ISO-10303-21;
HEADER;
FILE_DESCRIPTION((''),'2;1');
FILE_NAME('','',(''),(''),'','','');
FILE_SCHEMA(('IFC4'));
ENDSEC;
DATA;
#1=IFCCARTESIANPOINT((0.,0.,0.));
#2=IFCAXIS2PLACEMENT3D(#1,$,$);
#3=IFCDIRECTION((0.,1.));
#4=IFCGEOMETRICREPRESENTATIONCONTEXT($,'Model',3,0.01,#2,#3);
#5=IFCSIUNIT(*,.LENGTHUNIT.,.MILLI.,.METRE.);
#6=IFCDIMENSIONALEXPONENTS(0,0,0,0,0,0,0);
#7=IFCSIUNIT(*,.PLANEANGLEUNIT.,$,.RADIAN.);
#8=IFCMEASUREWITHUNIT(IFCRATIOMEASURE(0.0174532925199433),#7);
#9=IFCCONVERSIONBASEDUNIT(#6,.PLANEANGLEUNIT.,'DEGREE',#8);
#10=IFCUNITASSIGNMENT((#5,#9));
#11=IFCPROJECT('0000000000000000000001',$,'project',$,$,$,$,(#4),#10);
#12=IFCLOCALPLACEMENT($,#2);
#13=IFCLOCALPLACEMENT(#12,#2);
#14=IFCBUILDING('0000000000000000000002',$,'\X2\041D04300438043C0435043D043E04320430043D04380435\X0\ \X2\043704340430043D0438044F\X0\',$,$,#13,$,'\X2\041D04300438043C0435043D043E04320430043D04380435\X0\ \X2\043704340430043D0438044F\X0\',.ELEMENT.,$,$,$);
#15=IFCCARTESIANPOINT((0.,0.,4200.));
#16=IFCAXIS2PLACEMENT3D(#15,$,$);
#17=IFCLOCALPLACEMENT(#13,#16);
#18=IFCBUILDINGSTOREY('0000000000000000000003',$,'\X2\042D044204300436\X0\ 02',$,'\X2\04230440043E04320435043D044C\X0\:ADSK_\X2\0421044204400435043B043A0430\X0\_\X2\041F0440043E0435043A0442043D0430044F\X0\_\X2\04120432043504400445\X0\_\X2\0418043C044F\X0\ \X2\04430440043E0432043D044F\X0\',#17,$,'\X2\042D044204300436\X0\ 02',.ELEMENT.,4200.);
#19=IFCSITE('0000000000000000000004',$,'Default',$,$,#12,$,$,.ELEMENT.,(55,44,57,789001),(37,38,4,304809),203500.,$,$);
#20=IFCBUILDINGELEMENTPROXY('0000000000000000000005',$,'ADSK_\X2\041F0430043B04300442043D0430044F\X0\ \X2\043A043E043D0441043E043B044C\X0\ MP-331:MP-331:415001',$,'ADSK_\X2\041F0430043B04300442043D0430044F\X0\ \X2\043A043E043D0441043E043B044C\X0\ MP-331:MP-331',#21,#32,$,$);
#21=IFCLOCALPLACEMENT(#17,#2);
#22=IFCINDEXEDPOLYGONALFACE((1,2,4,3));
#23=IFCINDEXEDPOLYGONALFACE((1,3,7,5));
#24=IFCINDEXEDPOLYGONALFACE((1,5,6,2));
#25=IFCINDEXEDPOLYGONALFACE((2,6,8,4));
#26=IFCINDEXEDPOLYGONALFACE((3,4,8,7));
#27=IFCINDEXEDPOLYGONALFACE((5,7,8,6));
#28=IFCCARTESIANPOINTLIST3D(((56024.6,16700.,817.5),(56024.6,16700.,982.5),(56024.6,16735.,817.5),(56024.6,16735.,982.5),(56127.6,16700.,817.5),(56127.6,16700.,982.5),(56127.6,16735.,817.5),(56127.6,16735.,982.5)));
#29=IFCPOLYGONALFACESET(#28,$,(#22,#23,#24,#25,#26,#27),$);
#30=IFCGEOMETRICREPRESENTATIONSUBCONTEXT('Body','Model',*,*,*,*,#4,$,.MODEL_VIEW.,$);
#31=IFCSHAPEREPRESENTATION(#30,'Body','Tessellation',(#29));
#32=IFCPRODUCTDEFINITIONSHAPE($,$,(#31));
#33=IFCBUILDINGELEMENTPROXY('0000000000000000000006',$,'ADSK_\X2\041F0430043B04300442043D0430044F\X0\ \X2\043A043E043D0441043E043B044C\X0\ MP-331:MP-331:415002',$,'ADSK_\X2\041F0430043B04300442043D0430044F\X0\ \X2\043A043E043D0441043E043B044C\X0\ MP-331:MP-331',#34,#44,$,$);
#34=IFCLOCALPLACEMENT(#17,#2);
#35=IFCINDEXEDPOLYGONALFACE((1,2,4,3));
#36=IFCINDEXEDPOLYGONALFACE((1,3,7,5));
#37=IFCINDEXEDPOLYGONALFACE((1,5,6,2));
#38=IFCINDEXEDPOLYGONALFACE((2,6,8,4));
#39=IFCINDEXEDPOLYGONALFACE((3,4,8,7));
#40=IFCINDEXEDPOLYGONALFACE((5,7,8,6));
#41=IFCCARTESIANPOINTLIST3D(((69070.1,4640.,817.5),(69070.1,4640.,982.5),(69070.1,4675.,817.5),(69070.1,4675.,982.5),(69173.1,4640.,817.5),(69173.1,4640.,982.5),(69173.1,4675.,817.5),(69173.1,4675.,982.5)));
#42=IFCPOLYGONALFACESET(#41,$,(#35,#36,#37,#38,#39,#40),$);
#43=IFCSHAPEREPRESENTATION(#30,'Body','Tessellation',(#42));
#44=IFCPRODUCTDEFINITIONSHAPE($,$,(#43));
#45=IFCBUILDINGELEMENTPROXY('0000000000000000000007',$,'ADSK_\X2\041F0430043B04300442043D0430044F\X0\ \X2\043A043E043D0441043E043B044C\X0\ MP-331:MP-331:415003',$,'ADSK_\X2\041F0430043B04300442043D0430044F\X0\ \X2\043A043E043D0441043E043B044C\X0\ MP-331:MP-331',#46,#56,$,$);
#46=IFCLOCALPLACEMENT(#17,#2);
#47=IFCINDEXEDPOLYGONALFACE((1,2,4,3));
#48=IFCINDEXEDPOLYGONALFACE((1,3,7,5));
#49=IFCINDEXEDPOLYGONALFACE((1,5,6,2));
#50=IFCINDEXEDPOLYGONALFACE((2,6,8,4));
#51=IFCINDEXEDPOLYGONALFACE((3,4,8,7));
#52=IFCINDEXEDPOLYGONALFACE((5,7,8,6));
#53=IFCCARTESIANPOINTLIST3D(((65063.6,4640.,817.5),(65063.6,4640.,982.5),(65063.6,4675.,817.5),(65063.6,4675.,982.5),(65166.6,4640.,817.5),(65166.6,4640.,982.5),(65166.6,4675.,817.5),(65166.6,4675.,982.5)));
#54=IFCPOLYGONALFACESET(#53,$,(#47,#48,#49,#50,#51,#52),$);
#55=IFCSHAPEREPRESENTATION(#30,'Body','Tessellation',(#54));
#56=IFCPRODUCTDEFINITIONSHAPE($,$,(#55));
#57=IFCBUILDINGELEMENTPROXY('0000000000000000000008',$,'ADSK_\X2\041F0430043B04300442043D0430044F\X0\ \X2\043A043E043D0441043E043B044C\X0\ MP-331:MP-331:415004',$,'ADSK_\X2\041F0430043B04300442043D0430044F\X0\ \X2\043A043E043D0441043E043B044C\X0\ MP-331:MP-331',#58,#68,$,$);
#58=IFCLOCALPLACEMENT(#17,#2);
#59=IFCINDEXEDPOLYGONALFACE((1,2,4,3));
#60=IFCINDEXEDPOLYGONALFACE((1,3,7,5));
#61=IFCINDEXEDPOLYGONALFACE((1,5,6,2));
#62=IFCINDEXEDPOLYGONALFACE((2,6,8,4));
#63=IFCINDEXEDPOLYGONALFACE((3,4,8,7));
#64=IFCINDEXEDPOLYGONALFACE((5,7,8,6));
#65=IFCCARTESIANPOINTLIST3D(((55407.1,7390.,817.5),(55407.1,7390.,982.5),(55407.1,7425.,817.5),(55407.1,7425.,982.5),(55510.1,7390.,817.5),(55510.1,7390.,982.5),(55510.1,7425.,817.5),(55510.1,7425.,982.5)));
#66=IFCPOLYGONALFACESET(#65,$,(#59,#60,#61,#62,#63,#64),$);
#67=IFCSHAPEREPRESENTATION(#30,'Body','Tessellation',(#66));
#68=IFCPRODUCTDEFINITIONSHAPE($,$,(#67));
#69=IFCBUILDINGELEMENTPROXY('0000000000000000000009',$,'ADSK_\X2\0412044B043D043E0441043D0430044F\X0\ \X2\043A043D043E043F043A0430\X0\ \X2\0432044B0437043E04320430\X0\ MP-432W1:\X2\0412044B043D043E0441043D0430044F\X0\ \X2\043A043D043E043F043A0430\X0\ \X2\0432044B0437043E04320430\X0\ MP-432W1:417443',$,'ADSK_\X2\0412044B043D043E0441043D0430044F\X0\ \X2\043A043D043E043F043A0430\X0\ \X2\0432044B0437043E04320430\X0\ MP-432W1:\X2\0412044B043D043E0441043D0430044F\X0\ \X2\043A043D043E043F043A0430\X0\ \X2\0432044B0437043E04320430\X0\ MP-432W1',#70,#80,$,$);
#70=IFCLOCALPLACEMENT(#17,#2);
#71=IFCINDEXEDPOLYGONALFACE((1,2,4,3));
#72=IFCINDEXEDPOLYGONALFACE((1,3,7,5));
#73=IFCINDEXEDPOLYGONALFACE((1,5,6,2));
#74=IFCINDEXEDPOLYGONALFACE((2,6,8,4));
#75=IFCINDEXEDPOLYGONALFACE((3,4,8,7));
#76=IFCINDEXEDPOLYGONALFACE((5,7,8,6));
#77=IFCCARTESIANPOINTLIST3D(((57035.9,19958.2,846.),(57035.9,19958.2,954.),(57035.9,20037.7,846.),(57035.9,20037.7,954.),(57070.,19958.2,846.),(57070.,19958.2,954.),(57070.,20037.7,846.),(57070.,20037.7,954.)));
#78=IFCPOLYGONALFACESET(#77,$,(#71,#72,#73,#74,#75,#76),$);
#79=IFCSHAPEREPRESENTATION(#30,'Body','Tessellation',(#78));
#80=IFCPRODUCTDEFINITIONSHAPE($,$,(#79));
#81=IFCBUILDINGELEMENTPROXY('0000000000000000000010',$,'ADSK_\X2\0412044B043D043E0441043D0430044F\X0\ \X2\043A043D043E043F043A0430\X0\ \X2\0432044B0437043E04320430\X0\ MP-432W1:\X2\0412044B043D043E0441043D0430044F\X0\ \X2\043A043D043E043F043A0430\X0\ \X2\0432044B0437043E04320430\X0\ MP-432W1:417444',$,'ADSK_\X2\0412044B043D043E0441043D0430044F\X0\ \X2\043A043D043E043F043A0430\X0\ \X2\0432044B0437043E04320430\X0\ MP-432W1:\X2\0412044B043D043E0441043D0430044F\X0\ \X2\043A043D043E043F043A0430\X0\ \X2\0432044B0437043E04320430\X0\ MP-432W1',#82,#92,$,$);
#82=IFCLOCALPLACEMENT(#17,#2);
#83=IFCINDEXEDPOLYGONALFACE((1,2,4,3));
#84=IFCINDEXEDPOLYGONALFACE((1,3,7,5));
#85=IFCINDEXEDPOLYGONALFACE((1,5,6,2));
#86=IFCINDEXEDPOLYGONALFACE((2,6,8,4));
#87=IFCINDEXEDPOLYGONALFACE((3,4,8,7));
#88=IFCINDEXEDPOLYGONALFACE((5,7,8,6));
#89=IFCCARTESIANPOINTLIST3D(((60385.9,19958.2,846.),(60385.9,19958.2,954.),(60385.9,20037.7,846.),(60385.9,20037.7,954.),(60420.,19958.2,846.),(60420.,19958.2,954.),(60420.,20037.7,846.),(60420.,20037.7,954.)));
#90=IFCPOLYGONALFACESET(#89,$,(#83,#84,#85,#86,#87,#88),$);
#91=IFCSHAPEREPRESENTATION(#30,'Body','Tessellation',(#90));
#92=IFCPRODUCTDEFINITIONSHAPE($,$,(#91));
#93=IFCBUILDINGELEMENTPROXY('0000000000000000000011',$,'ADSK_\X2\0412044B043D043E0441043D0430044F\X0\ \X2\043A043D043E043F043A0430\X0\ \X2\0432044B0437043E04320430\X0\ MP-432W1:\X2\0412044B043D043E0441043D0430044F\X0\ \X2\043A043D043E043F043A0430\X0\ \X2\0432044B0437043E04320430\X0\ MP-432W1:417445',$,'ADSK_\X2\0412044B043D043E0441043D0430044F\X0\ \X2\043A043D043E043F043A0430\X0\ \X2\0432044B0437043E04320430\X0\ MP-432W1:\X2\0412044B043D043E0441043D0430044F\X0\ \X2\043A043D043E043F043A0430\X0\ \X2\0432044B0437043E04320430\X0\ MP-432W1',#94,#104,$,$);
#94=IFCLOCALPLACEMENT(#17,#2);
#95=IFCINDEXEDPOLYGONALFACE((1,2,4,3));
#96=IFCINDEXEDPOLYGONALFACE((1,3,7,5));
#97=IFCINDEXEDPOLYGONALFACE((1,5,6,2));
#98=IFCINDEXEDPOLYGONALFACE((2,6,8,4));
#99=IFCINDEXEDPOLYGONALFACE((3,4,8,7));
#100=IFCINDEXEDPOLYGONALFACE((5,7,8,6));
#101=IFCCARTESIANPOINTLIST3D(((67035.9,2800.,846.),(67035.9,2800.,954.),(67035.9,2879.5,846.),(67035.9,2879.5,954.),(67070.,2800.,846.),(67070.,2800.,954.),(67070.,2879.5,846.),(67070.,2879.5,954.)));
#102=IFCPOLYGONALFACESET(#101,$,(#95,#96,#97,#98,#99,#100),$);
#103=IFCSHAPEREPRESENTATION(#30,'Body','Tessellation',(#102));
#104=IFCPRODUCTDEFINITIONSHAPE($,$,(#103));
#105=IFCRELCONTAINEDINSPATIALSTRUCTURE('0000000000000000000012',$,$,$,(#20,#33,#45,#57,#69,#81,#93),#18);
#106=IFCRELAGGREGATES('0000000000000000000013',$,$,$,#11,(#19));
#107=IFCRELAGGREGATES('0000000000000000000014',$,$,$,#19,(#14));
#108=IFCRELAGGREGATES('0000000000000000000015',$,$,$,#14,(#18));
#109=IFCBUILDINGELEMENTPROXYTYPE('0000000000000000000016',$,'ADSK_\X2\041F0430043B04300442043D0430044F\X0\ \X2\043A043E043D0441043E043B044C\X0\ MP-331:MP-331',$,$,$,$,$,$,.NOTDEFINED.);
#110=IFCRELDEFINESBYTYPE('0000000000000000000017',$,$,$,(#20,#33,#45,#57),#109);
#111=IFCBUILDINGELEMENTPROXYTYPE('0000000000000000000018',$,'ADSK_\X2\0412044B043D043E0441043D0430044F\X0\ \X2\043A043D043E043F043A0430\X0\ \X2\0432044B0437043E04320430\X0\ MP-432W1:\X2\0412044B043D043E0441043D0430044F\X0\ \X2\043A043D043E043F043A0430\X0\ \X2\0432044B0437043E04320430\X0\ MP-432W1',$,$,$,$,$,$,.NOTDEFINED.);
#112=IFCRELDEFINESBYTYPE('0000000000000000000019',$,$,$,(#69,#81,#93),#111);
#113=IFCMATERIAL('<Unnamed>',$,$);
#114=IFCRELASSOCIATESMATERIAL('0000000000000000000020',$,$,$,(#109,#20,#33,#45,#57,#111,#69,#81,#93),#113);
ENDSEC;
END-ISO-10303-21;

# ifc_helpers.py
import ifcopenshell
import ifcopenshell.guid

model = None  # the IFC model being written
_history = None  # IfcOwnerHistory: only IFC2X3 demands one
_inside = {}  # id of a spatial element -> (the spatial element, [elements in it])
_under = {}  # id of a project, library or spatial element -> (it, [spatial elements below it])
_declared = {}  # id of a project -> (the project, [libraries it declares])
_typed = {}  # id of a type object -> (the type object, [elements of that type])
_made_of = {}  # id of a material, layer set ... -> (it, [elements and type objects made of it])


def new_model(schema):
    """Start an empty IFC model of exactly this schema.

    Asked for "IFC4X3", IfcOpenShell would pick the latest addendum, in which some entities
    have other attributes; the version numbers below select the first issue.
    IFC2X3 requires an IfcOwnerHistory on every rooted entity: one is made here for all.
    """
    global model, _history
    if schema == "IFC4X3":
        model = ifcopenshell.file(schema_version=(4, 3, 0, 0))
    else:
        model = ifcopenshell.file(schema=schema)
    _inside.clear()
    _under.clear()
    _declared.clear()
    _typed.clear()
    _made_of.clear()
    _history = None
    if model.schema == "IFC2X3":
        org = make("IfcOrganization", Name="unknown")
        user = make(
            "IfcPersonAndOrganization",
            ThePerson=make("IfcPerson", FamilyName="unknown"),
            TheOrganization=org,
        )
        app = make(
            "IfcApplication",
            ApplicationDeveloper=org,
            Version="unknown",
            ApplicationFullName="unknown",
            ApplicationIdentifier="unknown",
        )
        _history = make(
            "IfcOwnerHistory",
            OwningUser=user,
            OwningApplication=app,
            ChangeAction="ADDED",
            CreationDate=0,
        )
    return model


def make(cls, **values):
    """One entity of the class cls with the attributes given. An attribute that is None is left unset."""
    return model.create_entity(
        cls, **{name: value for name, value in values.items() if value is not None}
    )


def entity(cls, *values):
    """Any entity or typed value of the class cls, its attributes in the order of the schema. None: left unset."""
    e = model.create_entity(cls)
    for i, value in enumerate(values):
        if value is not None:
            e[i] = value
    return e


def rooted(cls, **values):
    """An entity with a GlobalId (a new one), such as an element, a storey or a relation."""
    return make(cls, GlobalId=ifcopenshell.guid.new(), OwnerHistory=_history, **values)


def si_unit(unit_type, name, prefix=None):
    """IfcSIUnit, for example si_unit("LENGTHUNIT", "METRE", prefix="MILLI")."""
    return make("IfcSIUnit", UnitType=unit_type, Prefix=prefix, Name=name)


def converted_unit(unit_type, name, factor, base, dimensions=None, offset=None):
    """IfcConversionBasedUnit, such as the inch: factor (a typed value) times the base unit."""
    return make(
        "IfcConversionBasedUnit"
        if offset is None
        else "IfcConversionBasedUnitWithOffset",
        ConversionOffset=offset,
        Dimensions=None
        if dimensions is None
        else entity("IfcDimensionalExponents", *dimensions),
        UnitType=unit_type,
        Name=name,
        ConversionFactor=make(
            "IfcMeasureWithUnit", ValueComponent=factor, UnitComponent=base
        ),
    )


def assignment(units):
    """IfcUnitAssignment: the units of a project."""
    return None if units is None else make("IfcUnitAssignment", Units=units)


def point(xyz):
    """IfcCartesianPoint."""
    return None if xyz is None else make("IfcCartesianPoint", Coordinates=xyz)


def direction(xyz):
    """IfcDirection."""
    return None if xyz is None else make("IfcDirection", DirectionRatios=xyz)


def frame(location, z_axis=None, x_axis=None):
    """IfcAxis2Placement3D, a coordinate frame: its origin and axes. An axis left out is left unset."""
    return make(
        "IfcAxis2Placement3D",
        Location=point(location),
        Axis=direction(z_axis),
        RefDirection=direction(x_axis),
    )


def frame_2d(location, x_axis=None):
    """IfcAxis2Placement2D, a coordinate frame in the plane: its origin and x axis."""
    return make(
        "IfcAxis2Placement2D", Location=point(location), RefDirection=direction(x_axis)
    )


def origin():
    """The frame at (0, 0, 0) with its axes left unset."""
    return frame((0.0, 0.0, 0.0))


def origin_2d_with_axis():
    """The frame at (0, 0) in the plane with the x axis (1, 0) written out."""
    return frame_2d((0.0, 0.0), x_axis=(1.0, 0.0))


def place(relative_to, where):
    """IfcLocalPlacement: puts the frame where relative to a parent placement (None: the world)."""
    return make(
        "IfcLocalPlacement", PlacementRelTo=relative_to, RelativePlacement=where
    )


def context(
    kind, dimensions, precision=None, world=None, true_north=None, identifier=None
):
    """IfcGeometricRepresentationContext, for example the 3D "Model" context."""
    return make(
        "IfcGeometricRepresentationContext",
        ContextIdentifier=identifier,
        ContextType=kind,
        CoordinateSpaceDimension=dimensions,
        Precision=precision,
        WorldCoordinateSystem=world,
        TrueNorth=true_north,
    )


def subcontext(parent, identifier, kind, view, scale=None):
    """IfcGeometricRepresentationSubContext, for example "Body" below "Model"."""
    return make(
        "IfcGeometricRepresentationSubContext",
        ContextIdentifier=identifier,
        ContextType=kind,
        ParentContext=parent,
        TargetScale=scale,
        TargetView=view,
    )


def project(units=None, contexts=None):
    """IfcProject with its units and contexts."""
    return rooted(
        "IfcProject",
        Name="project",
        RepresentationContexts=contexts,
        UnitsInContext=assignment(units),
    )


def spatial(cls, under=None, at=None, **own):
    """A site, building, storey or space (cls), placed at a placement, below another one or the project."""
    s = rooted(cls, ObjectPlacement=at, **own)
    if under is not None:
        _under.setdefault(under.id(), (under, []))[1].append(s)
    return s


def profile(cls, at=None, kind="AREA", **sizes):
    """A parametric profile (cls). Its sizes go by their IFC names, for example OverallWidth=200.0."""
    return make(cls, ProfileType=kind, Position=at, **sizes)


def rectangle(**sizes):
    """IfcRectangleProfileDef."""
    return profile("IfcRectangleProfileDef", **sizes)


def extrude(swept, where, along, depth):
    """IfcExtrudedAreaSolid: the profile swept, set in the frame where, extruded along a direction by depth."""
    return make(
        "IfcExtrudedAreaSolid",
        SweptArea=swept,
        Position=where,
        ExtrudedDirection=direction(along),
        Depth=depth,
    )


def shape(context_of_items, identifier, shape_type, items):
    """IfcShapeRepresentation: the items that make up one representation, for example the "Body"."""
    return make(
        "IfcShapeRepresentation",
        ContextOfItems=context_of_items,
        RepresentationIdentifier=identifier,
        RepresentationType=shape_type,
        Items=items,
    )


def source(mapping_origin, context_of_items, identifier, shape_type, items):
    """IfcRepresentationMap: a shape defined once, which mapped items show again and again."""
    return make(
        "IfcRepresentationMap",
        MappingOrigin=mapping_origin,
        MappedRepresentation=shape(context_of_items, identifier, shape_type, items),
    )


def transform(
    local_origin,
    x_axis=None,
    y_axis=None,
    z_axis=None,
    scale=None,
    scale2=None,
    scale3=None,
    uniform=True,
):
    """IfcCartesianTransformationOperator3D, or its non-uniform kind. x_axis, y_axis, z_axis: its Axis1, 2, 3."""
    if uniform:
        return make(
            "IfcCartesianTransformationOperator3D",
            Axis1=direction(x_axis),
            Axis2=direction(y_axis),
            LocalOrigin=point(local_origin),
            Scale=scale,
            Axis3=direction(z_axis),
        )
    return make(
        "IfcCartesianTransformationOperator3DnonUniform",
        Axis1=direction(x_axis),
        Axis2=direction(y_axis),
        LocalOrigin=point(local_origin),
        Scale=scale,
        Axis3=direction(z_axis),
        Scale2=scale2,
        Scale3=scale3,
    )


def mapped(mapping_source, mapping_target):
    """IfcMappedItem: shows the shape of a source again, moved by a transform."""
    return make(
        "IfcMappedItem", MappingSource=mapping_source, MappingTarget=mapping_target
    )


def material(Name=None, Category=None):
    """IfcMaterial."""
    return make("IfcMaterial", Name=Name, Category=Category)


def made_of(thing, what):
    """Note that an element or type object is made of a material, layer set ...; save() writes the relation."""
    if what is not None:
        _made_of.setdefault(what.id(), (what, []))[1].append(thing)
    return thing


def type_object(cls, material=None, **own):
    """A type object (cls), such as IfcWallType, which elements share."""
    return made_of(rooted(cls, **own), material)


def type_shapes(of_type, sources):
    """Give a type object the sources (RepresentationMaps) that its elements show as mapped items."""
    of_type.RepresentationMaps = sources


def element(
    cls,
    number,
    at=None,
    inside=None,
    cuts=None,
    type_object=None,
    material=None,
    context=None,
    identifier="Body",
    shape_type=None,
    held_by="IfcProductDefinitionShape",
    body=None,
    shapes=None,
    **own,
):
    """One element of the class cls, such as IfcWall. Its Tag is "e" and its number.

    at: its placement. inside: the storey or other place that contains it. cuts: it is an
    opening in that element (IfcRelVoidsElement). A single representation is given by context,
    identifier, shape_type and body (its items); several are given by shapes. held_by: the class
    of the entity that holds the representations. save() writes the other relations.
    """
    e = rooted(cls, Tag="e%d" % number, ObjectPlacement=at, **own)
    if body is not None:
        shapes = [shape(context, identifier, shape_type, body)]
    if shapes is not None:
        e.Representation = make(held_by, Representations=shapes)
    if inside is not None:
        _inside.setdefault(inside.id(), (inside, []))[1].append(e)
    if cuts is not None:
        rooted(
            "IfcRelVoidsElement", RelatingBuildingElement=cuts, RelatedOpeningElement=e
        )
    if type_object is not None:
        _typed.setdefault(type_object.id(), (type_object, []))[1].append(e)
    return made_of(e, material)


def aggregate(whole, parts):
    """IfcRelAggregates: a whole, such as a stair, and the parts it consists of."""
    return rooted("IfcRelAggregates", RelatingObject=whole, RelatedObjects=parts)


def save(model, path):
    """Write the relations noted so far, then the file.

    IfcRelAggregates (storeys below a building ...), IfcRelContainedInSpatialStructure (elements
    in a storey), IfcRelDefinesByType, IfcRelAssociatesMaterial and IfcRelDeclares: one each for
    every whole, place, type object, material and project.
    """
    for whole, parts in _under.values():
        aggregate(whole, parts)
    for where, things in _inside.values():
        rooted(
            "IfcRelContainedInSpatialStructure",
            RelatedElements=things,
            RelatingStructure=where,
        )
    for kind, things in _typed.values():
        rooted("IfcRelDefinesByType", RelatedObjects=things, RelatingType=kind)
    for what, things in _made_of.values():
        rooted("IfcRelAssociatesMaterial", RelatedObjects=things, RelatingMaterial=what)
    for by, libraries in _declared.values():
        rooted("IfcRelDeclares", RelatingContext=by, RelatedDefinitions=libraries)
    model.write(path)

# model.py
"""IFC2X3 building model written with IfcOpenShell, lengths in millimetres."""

from ifc_helpers import new_model, entity, si_unit, converted_unit, direction, frame, origin, origin_2d_with_axis, place, context, subcontext, project, spatial, rectangle, extrude, source, transform, mapped, material, type_object, type_shapes, element, save


model = new_model("IFC2X3")

# Units and contexts
model_context = context("Model", 3, precision=0.01, world=origin(), true_north=direction((0.0, 1.0)))
body_context = subcontext(model_context, "Body", "Model", "MODEL_VIEW")
ifc_project = project(units=[si_unit("LENGTHUNIT", "METRE", prefix="MILLI"), converted_unit("PLANEANGLEUNIT", "DEGREE", entity("IfcRatioMeasure", 0.0174532925199433), si_unit("PLANEANGLEUNIT", "RADIAN"), dimensions=[0, 0, 0, 0, 0, 0, 0])], contexts=[model_context])

# Site, building, storey
site_placement = place(None, origin())
site = spatial("IfcSite", under=ifc_project, at=site_placement, Name="Default", CompositionType="ELEMENT", RefLatitude=(55, 44, 57, 789001), RefLongitude=(37, 38, 4, 304809), RefElevation=203500.0)
building_placement = place(site_placement, origin())
building = spatial("IfcBuilding", under=site, at=building_placement, Name="Наименование здания", LongName="Наименование здания", CompositionType="ELEMENT")
storey_placement = place(building_placement, frame((0.0, 0.0, 4200.0)))
storey = spatial("IfcBuildingStorey", under=building, at=storey_placement, Name="Этаж 02", ObjectType="Уровень:ADSK_Стрелка_Проектная_Вверх_Имя уровня", LongName="Этаж 02", CompositionType="ELEMENT", Elevation=4200.0)

# Building element proxies
ifc_material = material(Name="<Unnamed>")
building_element_proxy_type_1 = type_object("IfcBuildingElementProxyType", Name="ADSK_Палатная консоль MP-331:MP-331", PredefinedType="NOTDEFINED", material=ifc_material)
shared_shape_1 = source(origin(), body_context, "Body", "SweptSolid", [
    extrude(rectangle(XDim=103.0, YDim=35.0, at=origin_2d_with_axis()), frame((0.0, 14.5, -82.5), z_axis=(0.0, 0.0, 1.0), x_axis=(-1.0, 0.0, 0.0)), (0.0, 0.0, 1.0), 165.0),
])
type_shapes(building_element_proxy_type_1, [shared_shape_1])
proxy_1_placement = place(storey_placement, frame((56076.1, 16732.0, 900.0), z_axis=(0.0, 0.0, 1.0), x_axis=(-1.0, 0.0, 0.0)))
element("IfcBuildingElementProxy", 1, at=proxy_1_placement, inside=storey, type_object=building_element_proxy_type_1, material=ifc_material, Name="ADSK_Палатная консоль MP-331:MP-331:415001", ObjectType="ADSK_Палатная консоль MP-331:MP-331", context=body_context, shape_type="MappedRepresentation", body=[
    mapped(shared_shape_1, transform((0.0, 0.0, 0.0), scale=1.0)),
])
for number, where, name in (
    (2, (69121.6, 4643.0, 900.0), "ADSK_Палатная консоль MP-331:MP-331:415002"),
    (3, (65115.1, 4643.0, 900.0), "ADSK_Палатная консоль MP-331:MP-331:415003"),
    (4, (55458.6, 7393.0, 900.0), "ADSK_Палатная консоль MP-331:MP-331:415004"),
):
    element("IfcBuildingElementProxy", number, at=place(storey_placement, frame(where)), inside=storey, type_object=building_element_proxy_type_1, material=ifc_material, Name=name, ObjectType="ADSK_Палатная консоль MP-331:MP-331", context=body_context, shape_type="MappedRepresentation", body=[
        mapped(shared_shape_1, transform((0.0, 0.0, 0.0), scale=1.0)),
    ])
building_element_proxy_type_2 = type_object("IfcBuildingElementProxyType", Name="ADSK_Выносная кнопка вызова MP-432W1:Выносная кнопка вызова MP-432W1", PredefinedType="NOTDEFINED", material=ifc_material)
shared_shape_2 = source(origin(), body_context, "Body", "SweptSolid", [
    extrude(rectangle(XDim=79.5, YDim=34.1, at=origin_2d_with_axis()), frame((0.0, 15.0, -54.0), z_axis=(0.0, 0.0, 1.0), x_axis=(-1.0, 0.0, 0.0)), (0.0, 0.0, 1.0), 108.0),
])
type_shapes(building_element_proxy_type_2, [shared_shape_2])
for number, where, z_axis, x_axis, name in (
    (5, (57038.0, 19997.9, 900.0), (0.0, 0.0, 1.0), (0.0, -1.0, 0.0), "ADSK_Выносная кнопка вызова MP-432W1:Выносная кнопка вызова MP-432W1:417443"),
    (6, (60388.0, 19997.9, 900.0), (0.0, 0.0, 1.0), (0.0, -1.0, 0.0), "ADSK_Выносная кнопка вызова MP-432W1:Выносная кнопка вызова MP-432W1:417444"),
    (7, (67038.0, 2839.8, 900.0), (0.0, 0.0, 1.0), (0.0, -1.0, 0.0), "ADSK_Выносная кнопка вызова MP-432W1:Выносная кнопка вызова MP-432W1:417445"),
):
    element("IfcBuildingElementProxy", number, at=place(storey_placement, frame(where, z_axis=z_axis, x_axis=x_axis)), inside=storey, type_object=building_element_proxy_type_2, material=ifc_material, Name=name, ObjectType="ADSK_Выносная кнопка вызова MP-432W1:Выносная кнопка вызова MP-432W1", context=body_context, shape_type="MappedRepresentation", body=[
        mapped(shared_shape_2, transform((0.0, 0.0, 0.0), scale=1.0)),
    ])

save(model, "model.ifc")
